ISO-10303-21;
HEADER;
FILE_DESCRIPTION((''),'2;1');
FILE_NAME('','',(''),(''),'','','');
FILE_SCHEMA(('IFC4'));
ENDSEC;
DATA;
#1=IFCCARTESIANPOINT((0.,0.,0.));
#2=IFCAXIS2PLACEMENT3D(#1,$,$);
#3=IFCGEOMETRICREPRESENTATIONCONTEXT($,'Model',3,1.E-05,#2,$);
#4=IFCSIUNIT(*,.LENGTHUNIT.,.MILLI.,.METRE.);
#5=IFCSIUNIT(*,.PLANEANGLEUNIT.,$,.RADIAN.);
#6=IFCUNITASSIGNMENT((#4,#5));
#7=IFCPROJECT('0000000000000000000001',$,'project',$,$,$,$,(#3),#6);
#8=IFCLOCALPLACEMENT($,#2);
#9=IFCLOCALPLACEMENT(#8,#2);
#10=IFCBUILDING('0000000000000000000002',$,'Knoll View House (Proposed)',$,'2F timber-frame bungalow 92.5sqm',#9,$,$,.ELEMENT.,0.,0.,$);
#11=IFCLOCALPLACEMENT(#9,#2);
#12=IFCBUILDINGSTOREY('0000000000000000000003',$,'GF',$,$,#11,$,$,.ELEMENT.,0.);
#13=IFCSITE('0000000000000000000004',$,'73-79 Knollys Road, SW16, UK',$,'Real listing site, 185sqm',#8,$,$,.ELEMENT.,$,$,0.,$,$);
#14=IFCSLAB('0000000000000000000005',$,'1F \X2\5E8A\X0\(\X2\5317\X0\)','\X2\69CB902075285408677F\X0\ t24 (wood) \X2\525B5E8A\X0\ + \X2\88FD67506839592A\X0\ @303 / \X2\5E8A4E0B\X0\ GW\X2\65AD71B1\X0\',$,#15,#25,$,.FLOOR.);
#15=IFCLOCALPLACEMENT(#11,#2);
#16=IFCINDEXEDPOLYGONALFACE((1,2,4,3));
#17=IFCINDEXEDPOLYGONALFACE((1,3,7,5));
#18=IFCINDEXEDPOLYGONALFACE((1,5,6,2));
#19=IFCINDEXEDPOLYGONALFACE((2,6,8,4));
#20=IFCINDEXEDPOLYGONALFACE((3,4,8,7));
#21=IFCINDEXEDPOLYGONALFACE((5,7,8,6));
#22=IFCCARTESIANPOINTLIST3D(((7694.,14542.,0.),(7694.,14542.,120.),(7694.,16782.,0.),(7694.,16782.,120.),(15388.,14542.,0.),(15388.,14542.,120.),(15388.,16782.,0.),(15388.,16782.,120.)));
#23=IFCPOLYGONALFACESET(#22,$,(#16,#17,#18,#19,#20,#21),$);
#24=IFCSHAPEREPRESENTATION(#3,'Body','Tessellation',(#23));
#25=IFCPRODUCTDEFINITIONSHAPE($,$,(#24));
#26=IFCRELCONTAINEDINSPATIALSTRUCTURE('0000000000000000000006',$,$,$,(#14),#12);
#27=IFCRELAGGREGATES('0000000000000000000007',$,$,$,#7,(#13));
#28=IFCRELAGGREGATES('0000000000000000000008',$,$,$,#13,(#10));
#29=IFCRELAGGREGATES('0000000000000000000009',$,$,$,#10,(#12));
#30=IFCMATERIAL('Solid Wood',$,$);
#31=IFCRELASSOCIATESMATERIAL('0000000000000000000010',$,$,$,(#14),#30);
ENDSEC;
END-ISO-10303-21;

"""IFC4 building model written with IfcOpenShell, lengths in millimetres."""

from ifc_helpers import new_model, si_unit, frame, frame_2d, origin, place, context, project, spatial, rectangle, extrude, material, element, save


model = new_model("IFC4")

# Units and contexts
model_context = context("Model", 3, precision=1e-05, world=origin())
ifc_project = project(units=[si_unit("LENGTHUNIT", "METRE", prefix="MILLI"), si_unit("PLANEANGLEUNIT", "RADIAN")], contexts=[model_context])

# Site, building, storey
site_placement = place(None, origin())
site = spatial("IfcSite", under=ifc_project, at=site_placement, Name="73-79 Knollys Road, SW16, UK", ObjectType="Real listing site, 185sqm", CompositionType="ELEMENT", RefElevation=0.0)
building_placement = place(site_placement, origin())
building = spatial("IfcBuilding", under=site, at=building_placement, Name="Knoll View House (Proposed)", ObjectType="2F timber-frame bungalow 92.5sqm", CompositionType="ELEMENT", ElevationOfRefHeight=0.0, ElevationOfTerrain=0.0)
storey_placement = place(building_placement, origin())
storey = spatial("IfcBuildingStorey", under=building, at=storey_placement, Name="GF", CompositionType="ELEMENT", Elevation=0.0)

# Slab
ifc_material_1 = material(Name="Solid Wood")
slab_1_placement = place(storey_placement, frame((3847.0, 7271.0, 0.0)))
element("IfcSlab", 1, at=slab_1_placement, inside=storey, material=ifc_material_1, Name="1F 床(北)", Description="構造用合板 t24 (wood) 剛床 + 製材根太 @303 / 床下 GW断熱", PredefinedType="FLOOR", context=model_context, shape_type="SweptSolid", body=[
    extrude(rectangle(XDim=7694.0, YDim=2240.0, at=frame_2d((3847.0, 1120.0))), frame((3847.0, 7271.0, 0.0)), (0.0, 0.0, 1.0), 120.0),
])

save(model, "model.ifc")
